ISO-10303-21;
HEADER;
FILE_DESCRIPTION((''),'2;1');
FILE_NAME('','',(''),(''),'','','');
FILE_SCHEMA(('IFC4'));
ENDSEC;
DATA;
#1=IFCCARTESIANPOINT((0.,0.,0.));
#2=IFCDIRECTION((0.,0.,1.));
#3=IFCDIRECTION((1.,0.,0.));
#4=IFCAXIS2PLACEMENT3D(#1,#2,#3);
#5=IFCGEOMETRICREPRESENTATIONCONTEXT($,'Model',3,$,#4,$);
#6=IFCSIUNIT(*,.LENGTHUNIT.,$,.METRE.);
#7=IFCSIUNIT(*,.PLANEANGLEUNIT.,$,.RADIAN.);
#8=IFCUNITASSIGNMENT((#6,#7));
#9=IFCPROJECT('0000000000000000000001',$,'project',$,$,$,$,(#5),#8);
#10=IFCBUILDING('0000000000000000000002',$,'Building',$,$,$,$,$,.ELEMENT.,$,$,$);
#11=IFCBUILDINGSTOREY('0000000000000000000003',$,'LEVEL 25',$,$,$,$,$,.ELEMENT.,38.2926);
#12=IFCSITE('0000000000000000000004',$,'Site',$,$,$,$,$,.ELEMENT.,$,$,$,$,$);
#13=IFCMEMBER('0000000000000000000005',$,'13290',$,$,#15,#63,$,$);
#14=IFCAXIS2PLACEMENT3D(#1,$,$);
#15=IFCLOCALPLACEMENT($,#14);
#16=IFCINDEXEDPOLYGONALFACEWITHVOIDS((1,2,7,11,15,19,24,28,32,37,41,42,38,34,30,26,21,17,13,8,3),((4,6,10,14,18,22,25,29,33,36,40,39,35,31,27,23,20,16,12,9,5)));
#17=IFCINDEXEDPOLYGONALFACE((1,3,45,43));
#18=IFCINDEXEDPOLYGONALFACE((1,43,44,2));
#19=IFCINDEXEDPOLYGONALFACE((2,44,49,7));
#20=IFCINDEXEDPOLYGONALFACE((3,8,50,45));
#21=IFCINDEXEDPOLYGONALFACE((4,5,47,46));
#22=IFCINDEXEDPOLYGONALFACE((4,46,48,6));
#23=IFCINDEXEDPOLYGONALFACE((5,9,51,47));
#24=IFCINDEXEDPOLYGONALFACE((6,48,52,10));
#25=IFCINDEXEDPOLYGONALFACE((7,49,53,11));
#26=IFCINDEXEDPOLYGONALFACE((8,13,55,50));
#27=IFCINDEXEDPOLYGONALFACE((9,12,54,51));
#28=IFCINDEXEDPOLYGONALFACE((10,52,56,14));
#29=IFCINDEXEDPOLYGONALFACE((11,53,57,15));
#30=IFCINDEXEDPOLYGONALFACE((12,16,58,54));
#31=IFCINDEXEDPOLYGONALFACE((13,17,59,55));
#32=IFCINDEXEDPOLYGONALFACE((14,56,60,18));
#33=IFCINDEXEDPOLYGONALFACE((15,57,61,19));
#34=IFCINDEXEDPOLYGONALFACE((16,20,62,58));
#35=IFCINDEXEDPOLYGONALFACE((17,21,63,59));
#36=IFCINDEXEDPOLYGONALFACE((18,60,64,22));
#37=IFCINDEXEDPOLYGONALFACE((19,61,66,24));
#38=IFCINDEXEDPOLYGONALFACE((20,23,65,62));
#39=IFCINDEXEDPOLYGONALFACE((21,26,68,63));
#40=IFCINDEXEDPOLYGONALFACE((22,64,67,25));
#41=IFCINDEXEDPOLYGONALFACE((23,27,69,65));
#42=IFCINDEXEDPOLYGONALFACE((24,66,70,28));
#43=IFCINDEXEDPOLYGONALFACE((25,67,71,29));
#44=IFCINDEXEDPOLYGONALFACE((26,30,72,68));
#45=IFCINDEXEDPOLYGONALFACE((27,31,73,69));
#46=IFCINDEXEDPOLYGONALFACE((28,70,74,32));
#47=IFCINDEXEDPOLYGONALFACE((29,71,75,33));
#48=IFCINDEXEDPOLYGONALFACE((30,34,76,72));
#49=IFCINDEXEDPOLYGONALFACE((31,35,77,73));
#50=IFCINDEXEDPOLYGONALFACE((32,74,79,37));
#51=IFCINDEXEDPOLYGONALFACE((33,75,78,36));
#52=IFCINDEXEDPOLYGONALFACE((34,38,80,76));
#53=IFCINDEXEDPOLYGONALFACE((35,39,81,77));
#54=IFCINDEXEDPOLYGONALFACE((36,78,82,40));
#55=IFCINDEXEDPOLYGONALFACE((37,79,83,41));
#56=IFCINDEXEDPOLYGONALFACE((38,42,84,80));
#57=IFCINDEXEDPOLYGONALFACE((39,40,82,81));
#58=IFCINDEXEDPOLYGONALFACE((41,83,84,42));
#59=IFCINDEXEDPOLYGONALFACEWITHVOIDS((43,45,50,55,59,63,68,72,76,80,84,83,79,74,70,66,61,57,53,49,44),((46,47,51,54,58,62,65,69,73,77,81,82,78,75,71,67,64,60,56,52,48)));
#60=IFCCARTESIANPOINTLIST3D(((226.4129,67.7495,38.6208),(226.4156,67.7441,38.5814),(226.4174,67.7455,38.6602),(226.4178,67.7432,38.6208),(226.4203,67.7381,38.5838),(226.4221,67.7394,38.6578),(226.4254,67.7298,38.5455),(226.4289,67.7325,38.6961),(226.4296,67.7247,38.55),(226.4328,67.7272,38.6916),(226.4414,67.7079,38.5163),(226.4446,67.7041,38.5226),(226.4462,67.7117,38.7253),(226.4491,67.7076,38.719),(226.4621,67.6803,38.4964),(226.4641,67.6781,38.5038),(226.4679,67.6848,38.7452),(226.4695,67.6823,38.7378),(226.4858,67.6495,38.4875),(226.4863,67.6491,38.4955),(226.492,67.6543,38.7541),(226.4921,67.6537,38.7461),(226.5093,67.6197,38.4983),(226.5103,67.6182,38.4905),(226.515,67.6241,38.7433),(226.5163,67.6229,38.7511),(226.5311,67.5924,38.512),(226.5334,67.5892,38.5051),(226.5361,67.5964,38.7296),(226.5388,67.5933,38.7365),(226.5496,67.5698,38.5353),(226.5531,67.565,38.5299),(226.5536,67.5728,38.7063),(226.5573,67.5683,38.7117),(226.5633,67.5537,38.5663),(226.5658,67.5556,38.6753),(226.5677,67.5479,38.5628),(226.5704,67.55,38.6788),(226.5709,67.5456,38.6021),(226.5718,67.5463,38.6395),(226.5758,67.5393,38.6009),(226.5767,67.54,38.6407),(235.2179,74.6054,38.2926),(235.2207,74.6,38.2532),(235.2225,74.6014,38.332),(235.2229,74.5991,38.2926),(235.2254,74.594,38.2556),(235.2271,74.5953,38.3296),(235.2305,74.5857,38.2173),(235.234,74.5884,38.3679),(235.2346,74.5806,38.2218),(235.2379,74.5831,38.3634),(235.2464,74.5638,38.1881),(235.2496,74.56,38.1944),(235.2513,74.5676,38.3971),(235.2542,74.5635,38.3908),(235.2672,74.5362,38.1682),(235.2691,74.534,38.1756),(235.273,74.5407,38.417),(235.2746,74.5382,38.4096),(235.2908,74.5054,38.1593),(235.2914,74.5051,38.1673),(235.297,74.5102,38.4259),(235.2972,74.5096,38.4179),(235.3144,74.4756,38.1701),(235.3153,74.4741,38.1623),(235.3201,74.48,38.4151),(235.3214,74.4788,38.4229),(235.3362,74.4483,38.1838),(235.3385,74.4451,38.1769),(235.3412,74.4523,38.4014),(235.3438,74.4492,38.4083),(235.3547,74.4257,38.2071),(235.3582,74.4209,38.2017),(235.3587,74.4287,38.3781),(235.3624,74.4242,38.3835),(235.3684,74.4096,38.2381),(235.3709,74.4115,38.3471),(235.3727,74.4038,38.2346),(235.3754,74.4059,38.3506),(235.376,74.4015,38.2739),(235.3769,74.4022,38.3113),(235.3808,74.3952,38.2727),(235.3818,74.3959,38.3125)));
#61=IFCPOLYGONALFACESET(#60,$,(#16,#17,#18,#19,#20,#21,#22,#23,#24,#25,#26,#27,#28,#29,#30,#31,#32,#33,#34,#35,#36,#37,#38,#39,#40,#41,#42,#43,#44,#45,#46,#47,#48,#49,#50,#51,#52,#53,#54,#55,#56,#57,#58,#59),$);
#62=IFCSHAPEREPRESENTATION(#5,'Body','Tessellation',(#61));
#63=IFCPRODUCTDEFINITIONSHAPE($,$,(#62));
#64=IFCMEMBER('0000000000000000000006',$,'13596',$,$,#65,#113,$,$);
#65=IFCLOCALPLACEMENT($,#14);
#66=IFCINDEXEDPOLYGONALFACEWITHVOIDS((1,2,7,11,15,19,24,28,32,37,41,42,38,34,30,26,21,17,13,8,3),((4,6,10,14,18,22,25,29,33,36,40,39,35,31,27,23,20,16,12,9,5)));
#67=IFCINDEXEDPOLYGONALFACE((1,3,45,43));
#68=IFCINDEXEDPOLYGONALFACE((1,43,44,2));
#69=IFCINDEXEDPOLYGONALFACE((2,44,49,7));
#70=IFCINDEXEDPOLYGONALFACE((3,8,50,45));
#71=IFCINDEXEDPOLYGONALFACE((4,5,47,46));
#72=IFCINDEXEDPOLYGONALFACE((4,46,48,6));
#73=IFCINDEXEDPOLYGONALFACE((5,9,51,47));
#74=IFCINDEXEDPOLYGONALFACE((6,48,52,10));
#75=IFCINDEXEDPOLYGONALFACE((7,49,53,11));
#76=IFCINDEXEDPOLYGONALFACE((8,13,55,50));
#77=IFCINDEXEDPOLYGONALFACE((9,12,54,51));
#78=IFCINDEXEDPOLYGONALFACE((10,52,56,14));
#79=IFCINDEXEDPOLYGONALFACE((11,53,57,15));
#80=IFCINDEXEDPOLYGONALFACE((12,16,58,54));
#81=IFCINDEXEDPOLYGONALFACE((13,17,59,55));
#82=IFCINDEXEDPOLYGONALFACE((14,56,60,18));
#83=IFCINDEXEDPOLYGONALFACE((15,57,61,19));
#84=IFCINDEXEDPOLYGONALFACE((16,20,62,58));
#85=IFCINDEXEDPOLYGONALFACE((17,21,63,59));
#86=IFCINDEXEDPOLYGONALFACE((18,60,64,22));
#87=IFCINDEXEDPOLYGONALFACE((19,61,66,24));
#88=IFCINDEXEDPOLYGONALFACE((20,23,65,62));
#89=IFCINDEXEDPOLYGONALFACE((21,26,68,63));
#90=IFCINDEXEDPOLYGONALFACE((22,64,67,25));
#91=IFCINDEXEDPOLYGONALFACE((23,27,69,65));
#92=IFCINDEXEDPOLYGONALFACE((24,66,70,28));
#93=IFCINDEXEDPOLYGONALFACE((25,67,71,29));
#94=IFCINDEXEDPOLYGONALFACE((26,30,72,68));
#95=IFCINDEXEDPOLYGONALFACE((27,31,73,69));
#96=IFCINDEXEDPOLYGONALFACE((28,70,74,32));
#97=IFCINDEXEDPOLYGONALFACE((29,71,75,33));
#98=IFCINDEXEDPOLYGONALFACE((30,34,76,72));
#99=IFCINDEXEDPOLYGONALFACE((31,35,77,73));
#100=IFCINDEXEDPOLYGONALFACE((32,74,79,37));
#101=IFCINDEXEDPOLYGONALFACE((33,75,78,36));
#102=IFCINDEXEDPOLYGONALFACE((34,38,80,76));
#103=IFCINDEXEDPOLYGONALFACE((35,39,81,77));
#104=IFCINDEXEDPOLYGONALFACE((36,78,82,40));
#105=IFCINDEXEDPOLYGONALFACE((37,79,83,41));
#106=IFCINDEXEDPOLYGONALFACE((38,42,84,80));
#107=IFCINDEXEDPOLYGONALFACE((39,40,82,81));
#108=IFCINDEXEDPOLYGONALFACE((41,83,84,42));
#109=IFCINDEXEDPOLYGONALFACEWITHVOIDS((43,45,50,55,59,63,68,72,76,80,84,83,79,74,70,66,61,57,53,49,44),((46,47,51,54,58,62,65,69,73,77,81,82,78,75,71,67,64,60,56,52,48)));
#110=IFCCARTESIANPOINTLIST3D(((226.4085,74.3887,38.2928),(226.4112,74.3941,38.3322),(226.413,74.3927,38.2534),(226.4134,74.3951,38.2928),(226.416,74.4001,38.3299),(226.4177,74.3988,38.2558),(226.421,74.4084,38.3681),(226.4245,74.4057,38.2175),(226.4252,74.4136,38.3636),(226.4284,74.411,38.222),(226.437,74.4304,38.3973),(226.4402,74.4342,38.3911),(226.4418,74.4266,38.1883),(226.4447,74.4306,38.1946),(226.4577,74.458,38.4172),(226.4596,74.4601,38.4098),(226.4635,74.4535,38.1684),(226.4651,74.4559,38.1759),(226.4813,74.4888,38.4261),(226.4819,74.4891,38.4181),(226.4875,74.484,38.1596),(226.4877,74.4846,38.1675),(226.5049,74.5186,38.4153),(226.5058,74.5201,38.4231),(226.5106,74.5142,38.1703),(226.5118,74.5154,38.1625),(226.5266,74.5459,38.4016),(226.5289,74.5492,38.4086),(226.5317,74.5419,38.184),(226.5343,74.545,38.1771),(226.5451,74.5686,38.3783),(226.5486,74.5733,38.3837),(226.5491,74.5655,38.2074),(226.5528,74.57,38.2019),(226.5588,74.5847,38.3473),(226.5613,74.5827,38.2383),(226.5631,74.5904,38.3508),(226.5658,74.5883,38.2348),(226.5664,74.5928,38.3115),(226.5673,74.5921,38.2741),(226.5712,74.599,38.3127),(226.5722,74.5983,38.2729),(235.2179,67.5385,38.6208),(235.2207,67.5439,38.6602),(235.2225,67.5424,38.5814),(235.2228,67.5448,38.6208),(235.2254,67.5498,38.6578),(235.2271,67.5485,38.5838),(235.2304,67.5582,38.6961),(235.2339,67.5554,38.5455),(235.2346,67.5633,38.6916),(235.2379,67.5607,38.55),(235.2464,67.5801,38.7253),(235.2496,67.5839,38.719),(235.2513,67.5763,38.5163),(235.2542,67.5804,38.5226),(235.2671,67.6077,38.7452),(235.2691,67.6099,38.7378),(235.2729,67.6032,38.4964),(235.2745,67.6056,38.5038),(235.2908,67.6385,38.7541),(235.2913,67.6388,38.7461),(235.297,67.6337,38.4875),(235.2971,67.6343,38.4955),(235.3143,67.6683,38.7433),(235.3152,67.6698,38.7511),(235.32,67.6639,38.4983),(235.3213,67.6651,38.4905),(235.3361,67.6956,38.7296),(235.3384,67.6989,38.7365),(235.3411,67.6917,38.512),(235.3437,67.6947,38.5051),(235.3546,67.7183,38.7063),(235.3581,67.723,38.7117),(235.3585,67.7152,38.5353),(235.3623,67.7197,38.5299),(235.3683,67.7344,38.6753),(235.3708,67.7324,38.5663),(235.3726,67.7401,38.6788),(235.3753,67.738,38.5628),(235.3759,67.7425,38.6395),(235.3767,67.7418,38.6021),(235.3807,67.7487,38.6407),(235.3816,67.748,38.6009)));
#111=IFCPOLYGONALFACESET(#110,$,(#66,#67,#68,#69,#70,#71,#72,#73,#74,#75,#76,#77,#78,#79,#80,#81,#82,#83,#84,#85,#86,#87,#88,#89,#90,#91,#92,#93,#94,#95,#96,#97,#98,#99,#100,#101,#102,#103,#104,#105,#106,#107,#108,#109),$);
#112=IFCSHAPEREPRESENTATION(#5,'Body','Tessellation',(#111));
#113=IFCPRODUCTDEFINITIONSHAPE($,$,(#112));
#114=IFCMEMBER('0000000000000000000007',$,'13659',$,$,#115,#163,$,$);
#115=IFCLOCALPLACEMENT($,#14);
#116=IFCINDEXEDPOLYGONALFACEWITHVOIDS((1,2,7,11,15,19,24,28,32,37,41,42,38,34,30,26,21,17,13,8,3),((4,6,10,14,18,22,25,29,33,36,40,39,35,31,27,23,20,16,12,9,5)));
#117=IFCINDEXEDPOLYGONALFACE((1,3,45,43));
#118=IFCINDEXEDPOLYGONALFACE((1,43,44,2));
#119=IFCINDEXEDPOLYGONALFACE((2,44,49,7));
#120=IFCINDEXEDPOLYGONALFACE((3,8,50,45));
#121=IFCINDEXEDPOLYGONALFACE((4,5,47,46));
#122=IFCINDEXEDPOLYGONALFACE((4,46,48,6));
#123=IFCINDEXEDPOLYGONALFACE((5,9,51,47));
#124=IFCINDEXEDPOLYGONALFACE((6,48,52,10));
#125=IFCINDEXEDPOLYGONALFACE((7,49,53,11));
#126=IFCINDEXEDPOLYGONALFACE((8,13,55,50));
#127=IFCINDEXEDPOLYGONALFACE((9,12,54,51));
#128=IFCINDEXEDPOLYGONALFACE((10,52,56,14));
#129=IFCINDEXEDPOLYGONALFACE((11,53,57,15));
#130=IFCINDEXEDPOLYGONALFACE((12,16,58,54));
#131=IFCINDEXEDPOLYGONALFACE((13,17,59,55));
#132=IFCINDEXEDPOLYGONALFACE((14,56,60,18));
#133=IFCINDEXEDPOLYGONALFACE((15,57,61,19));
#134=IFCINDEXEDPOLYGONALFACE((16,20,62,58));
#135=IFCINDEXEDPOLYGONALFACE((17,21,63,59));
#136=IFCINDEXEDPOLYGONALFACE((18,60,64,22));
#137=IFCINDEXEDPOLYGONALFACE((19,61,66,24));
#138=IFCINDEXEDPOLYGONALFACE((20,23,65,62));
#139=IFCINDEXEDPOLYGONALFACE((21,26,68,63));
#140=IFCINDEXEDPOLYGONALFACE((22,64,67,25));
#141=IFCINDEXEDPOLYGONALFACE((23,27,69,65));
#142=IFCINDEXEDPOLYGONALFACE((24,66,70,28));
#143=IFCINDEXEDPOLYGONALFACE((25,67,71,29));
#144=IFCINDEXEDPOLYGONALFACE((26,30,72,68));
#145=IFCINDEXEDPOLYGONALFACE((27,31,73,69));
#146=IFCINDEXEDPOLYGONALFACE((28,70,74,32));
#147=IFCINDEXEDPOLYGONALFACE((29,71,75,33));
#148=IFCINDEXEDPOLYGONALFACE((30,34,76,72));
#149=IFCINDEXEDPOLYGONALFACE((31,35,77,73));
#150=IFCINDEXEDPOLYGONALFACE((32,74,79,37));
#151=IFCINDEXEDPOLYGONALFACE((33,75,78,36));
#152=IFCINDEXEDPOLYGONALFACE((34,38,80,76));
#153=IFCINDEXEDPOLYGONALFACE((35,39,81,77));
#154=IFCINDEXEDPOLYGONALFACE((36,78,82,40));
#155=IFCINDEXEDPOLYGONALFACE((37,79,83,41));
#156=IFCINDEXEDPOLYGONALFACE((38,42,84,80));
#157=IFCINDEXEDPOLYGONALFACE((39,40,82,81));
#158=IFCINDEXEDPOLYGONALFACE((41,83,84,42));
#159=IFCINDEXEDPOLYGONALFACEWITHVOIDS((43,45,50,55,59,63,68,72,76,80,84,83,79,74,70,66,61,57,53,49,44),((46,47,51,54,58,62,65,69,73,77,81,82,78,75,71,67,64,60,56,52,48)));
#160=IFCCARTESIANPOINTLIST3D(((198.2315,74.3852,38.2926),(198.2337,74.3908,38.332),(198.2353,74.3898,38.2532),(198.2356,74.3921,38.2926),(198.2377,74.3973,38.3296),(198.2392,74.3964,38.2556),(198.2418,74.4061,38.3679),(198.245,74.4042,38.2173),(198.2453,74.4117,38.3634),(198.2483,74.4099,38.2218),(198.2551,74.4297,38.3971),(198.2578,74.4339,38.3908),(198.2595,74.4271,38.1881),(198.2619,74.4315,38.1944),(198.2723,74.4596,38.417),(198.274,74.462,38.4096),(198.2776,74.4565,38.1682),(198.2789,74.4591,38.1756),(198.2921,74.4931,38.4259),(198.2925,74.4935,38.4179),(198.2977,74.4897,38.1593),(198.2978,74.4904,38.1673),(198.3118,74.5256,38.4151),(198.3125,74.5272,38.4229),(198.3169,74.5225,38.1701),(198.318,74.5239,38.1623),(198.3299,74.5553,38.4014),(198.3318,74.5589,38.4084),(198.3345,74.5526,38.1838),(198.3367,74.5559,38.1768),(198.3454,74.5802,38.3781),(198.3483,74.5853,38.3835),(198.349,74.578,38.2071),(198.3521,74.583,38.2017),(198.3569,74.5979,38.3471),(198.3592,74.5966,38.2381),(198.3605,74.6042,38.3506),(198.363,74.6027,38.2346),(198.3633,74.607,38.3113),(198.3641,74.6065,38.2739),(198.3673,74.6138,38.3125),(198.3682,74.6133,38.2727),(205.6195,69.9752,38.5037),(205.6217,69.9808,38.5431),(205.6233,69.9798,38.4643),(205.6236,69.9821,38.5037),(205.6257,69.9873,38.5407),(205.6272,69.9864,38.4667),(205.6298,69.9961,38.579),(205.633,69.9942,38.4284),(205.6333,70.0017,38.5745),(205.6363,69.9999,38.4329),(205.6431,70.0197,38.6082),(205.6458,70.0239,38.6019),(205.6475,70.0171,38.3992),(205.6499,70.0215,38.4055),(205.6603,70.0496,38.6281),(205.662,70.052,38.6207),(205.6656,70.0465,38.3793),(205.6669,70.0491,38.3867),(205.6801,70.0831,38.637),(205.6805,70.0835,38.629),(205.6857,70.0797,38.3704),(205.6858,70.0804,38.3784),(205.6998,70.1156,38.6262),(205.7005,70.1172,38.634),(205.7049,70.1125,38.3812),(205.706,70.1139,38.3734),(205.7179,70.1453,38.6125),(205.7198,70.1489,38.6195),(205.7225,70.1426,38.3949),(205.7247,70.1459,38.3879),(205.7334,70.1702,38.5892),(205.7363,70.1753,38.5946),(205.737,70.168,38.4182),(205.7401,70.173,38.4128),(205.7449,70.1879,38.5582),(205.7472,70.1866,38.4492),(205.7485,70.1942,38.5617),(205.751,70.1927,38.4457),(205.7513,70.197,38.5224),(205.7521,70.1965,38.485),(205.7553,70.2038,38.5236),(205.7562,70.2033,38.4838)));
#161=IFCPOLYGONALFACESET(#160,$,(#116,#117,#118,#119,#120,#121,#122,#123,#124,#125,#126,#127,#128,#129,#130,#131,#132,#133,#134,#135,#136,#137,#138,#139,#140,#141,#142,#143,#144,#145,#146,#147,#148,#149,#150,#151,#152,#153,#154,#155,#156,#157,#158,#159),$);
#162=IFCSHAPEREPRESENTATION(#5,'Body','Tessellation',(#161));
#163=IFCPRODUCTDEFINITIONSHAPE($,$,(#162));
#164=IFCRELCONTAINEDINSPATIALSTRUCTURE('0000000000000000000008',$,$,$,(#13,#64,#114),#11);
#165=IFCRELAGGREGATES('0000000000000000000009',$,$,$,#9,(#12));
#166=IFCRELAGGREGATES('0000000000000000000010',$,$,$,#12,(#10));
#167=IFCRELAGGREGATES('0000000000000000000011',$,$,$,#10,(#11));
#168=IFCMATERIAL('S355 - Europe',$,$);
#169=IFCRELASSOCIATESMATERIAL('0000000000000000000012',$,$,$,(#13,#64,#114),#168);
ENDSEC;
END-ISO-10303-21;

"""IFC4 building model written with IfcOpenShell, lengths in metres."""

from ifc_helpers import new_model, si_unit, frame, origin_with_axes, origin_2d_with_axis, place, context, project, spatial, hollow_circle, extrude, material, material_profile, profile_set, profile_usage, element, save


model = new_model("IFC4")

# Units and contexts
model_context = context("Model", 3, world=origin_with_axes())
ifc_project = project(units=[si_unit("LENGTHUNIT", "METRE"), si_unit("PLANEANGLEUNIT", "RADIAN")], contexts=[model_context])

# Site, building, storey
site = spatial("IfcSite", under=ifc_project, Name="Site", CompositionType="ELEMENT")
building = spatial("IfcBuilding", under=site, Name="Building", CompositionType="ELEMENT")
storey = spatial("IfcBuildingStorey", under=building, Name="LEVEL 25", CompositionType="ELEMENT", Elevation=38.2926)

# Shared definitions
ifc_material = material(Name="S355 - Europe")

# Members
ifc_material_profile_1 = material_profile(ifc_material, hollow_circle(Radius=0.1337, WallThickness=0.008, at=origin_2d_with_axis()))
ifc_profile_set_1 = profile_set([ifc_material_profile_1])
ifc_profile_usage_1 = profile_usage(ifc_profile_set_1, cardinal=10)
member_1_placement = place(None, frame((226.495, 67.644, 38.6208), z_axis=(0.788685, 0.614094, -0.029397), x_axis=(-0.613857, 0.789418, 0.0)))
element("IfcMember", 1, at=member_1_placement, inside=storey, material=ifc_profile_usage_1, Name="13290", context=model_context, shape_type="SweptSolid", body=[
    extrude(hollow_circle(Radius=0.1337, WallThickness=0.008, at=origin_2d_with_axis()), origin_with_axes(), (0.0, 0.0, 1.0), 11.1642),
])
ifc_material_profile_2 = material_profile(ifc_material, hollow_circle(Radius=0.1337, WallThickness=0.008, at=origin_2d_with_axis()))
ifc_profile_set_2 = profile_set([ifc_material_profile_2])
ifc_profile_usage_2 = profile_usage(ifc_profile_set_2, cardinal=10)
member_2_placement = place(None, frame((235.3, 67.644, 38.6208), z_axis=(-0.789077, 0.613592, -0.029377), x_axis=(-0.613857, -0.789418, 0.0)))
element("IfcMember", 2, at=member_2_placement, inside=storey, material=ifc_profile_usage_2, Name="13596", context=model_context, shape_type="SweptSolid", body=[
    extrude(hollow_circle(Radius=0.1337, WallThickness=0.008, at=origin_2d_with_axis()), origin_with_axes(), (0.0, 0.0, 1.0), 11.1642),
])
ifc_material_profile_3 = material_profile(ifc_material, hollow_circle(Radius=0.1337, WallThickness=0.008, at=origin_2d_with_axis()))
ifc_profile_set_3 = profile_set([ifc_material_profile_3])
ifc_profile_usage_3 = profile_usage(ifc_profile_set_3, cardinal=10)
member_3_placement = place(None, frame((205.688, 70.09, 38.5037), z_axis=(-0.858401, 0.512392, -0.024527), x_axis=(-0.512546, -0.85866, 0.0)))
element("IfcMember", 3, at=member_3_placement, inside=storey, material=ifc_profile_usage_3, Name="13659", context=model_context, shape_type="SweptSolid", body=[
    extrude(hollow_circle(Radius=0.1337, WallThickness=0.008, at=origin_2d_with_axis()), origin_with_axes(), (0.0, 0.0, 1.0), 8.6067),
])

save(model, "model.ifc")
